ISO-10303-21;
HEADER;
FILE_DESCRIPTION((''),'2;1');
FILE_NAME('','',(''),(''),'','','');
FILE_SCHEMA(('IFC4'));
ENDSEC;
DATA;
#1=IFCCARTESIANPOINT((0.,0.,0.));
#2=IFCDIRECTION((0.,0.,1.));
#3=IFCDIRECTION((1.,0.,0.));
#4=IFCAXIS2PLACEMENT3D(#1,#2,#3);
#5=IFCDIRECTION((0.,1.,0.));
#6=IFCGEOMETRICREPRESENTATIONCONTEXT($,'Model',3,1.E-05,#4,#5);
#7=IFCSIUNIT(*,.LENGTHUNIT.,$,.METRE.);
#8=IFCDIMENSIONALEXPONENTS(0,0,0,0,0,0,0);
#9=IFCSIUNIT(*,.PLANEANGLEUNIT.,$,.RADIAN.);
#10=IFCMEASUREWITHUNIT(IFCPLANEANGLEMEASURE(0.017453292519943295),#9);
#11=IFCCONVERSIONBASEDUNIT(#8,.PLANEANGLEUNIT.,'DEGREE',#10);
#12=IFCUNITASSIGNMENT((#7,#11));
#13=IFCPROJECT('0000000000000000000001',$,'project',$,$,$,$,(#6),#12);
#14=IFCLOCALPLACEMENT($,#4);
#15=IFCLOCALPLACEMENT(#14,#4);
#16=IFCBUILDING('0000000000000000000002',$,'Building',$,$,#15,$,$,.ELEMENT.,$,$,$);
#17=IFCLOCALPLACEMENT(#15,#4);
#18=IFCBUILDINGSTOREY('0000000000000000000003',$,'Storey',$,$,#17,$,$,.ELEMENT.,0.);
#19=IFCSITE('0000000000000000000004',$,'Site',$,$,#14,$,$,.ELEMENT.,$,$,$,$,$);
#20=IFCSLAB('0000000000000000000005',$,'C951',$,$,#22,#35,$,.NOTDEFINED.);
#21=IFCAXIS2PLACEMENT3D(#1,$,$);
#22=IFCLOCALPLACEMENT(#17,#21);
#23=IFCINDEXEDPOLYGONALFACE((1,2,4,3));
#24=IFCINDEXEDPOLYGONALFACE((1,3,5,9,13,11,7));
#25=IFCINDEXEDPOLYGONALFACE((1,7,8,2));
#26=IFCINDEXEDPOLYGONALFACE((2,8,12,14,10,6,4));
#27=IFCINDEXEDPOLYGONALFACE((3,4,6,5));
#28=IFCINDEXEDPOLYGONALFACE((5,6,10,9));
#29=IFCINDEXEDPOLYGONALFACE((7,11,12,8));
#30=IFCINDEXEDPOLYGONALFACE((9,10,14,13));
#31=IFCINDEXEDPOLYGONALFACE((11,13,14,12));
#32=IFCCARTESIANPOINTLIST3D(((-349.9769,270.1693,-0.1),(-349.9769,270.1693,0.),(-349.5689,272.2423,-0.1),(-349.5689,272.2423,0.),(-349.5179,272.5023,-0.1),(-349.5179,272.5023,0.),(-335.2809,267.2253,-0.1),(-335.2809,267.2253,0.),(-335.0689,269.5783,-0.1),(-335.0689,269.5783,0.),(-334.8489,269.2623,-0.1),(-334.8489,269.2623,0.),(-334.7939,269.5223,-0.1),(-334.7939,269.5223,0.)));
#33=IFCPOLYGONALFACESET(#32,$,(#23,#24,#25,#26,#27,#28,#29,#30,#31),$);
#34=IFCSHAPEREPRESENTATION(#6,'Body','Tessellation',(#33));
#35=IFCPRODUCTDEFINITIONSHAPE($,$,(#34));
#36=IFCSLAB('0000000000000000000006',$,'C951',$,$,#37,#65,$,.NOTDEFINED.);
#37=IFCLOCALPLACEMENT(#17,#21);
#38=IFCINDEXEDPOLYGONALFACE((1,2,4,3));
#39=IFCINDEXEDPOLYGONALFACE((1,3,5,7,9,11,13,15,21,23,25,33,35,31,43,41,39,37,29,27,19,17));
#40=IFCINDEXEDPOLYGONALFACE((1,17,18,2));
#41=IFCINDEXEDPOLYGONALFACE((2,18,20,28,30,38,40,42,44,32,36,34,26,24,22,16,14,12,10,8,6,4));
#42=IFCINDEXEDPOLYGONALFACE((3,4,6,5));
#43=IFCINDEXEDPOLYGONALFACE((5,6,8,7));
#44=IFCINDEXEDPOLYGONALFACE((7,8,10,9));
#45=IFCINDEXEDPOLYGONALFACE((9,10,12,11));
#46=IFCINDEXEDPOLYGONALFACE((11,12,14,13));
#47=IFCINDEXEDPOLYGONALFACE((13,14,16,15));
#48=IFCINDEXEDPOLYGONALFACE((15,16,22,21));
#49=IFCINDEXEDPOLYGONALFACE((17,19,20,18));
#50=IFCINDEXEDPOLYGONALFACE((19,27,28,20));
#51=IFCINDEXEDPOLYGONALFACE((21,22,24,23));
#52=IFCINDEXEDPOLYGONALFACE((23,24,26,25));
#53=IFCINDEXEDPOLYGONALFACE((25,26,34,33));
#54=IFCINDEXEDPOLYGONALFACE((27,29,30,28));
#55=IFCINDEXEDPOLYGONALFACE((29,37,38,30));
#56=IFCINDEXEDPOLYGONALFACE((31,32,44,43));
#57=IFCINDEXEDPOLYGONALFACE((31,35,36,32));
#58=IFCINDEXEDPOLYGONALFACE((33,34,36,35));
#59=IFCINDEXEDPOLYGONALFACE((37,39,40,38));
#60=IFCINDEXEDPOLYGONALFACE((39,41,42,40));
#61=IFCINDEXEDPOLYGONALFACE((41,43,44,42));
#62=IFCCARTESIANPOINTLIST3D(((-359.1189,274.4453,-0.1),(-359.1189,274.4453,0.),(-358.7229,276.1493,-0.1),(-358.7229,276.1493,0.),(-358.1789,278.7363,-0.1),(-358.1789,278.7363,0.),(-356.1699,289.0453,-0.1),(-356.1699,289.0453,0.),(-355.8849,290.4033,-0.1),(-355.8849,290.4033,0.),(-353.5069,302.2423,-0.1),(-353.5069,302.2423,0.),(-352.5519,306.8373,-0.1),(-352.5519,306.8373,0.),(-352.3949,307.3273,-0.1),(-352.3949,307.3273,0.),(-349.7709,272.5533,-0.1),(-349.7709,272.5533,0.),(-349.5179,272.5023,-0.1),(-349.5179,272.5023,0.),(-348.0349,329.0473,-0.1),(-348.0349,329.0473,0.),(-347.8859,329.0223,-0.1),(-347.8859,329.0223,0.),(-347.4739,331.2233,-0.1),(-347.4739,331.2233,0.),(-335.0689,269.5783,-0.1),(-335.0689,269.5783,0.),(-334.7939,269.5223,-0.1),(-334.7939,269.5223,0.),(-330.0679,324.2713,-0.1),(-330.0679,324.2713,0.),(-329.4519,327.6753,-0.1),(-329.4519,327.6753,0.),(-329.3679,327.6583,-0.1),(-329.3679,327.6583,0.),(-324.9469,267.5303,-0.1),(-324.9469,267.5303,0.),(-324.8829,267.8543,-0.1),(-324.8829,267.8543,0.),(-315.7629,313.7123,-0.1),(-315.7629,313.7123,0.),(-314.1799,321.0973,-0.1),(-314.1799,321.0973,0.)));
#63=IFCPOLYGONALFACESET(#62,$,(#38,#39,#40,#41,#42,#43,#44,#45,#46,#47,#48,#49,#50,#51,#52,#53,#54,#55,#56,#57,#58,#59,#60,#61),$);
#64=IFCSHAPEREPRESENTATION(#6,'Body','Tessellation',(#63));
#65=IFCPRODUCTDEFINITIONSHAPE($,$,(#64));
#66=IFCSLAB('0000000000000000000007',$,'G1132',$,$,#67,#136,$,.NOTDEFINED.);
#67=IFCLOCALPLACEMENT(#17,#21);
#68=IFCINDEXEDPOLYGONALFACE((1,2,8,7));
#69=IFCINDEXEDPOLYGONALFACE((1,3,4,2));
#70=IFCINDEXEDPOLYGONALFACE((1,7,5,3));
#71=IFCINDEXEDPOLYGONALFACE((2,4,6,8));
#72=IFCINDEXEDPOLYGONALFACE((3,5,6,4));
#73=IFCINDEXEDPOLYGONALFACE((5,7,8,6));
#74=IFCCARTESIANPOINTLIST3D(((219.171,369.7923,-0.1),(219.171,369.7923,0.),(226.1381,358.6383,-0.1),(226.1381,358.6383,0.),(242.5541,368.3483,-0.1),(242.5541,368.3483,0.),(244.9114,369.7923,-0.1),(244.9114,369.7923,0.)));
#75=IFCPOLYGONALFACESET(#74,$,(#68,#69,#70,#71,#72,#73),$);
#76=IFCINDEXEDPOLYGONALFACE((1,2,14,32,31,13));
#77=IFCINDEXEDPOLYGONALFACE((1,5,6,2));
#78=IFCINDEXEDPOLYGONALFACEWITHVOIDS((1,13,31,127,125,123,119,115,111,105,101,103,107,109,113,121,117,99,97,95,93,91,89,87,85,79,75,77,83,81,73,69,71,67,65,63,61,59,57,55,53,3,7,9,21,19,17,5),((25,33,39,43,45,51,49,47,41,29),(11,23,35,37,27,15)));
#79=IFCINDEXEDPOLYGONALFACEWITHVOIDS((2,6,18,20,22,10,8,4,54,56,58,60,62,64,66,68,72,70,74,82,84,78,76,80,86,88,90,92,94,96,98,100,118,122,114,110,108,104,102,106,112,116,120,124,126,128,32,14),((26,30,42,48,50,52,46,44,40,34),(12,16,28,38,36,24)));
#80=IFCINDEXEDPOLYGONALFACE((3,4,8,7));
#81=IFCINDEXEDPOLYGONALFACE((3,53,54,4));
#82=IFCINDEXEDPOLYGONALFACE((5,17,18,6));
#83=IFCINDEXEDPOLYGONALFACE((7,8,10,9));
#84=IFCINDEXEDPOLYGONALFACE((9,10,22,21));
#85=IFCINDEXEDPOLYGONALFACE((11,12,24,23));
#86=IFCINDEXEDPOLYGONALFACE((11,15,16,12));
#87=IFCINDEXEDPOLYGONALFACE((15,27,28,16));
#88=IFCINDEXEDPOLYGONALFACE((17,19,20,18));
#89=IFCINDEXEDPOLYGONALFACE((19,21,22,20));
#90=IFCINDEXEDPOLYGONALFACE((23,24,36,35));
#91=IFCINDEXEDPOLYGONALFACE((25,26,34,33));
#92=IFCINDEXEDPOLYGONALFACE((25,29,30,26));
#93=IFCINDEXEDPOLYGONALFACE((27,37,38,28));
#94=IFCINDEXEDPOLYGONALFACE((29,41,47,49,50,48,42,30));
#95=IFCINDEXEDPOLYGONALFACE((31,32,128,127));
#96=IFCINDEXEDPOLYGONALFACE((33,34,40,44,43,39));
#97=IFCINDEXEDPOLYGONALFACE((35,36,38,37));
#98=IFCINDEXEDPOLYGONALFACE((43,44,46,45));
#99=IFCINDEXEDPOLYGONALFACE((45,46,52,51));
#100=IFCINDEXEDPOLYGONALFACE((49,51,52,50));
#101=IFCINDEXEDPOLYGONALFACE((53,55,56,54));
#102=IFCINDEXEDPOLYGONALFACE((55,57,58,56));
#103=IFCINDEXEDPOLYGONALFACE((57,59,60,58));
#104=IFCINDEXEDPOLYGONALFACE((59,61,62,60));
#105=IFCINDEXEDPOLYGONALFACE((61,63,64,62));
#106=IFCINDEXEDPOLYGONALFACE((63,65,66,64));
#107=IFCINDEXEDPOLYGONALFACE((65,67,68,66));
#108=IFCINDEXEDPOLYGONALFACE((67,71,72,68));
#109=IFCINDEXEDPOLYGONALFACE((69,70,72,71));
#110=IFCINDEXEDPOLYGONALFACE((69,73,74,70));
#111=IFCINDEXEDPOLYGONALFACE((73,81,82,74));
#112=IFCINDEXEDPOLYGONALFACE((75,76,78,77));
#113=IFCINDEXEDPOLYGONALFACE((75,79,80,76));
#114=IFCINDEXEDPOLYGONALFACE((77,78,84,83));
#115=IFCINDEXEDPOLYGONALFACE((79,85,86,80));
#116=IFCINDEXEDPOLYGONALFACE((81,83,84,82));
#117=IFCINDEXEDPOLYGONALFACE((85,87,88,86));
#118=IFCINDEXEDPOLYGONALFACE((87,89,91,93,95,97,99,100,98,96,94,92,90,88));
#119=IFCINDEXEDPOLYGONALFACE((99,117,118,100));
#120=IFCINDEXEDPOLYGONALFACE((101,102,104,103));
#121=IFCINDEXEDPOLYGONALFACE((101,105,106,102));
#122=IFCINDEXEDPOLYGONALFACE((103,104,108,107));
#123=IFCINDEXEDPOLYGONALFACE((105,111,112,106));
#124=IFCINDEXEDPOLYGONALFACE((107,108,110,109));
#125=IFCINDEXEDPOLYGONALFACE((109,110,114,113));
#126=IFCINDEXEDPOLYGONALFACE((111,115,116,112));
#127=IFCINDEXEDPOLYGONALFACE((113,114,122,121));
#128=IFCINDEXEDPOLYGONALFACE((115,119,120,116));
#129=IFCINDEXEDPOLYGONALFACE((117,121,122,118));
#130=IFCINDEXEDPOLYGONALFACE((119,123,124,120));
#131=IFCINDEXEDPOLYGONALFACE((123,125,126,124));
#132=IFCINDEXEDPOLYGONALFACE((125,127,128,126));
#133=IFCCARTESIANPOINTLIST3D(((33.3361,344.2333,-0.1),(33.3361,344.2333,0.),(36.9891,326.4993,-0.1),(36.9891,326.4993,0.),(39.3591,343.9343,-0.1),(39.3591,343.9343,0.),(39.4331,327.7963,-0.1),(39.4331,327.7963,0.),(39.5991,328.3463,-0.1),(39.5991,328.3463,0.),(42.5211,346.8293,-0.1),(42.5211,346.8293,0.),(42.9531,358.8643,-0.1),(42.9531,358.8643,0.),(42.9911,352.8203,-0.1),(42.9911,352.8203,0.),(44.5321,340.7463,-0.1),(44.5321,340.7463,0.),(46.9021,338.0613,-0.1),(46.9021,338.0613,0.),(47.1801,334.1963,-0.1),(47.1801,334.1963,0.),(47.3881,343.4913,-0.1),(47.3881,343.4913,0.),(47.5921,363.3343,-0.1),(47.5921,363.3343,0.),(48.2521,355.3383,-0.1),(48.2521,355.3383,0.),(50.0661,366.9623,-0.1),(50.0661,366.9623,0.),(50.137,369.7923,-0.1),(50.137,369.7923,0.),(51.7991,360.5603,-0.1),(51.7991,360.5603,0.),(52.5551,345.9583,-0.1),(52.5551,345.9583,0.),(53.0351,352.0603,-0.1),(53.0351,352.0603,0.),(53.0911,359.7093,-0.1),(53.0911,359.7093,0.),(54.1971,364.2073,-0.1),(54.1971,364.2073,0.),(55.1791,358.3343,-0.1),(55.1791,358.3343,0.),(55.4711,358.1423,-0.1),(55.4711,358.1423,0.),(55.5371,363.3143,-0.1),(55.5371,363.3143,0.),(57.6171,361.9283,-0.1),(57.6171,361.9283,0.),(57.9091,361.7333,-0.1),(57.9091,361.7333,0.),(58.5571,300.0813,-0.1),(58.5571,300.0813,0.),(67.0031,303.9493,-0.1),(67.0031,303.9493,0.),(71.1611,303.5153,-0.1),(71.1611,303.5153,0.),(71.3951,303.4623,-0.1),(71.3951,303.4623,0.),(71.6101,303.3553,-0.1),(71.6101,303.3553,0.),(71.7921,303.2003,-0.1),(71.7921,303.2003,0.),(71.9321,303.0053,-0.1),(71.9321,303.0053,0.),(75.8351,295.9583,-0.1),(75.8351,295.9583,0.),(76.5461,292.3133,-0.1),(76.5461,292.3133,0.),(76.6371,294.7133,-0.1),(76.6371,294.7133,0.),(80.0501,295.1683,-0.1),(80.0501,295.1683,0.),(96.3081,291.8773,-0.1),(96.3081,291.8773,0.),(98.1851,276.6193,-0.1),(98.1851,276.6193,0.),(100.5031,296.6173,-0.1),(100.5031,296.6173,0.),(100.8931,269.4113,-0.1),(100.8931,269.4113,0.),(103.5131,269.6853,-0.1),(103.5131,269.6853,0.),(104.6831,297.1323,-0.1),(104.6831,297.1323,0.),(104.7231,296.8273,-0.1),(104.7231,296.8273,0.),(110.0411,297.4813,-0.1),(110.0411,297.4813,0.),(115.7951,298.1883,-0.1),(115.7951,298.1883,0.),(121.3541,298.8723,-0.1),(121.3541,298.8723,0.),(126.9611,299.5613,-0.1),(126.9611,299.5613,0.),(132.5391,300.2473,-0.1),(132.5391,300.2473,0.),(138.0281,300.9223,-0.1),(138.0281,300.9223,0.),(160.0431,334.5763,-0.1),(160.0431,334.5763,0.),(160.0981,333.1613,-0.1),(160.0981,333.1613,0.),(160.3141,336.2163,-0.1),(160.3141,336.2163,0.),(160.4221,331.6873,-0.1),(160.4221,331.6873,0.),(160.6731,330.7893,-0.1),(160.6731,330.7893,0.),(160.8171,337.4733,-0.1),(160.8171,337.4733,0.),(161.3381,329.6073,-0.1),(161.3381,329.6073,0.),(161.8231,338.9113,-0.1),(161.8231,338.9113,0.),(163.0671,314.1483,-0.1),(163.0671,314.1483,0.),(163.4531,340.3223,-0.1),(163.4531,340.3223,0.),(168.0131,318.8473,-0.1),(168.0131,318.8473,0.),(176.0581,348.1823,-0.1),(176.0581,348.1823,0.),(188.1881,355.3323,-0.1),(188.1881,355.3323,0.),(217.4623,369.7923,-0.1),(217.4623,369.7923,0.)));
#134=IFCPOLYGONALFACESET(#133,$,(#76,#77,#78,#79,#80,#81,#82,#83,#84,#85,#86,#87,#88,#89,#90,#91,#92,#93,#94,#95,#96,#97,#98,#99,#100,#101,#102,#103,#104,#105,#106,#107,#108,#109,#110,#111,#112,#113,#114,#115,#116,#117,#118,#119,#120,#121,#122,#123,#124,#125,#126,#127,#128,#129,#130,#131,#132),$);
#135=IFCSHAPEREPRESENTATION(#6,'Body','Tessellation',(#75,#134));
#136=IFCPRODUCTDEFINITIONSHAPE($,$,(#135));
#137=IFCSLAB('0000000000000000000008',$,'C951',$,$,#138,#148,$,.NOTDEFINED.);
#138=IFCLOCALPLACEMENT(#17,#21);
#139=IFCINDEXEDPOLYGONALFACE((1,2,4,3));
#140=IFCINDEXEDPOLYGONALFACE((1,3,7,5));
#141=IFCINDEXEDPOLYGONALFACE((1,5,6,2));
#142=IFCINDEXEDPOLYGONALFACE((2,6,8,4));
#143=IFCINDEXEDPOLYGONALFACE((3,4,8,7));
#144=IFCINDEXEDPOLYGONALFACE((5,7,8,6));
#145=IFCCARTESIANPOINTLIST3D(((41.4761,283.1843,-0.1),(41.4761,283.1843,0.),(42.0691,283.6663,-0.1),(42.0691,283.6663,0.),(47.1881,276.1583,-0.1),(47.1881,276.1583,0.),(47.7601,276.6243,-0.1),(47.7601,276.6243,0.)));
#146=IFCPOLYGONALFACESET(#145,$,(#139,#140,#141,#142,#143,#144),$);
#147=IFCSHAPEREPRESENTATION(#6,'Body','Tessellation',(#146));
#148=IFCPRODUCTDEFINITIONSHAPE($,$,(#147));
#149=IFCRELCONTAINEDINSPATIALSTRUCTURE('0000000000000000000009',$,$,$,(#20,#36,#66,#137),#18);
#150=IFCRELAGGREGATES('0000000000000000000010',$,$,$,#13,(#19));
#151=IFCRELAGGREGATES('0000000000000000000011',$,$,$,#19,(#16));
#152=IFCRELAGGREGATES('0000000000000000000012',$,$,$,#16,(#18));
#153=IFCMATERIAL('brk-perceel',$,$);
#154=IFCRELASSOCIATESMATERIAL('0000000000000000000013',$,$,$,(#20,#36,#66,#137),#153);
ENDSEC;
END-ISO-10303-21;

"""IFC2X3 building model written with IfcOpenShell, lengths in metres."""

from ifc_helpers import new_model, entity, si_unit, converted_unit, direction, frame, origin_with_axes, place, context, project, spatial, polyline, outline, extrude, material, element, save


model = new_model("IFC2X3")

# Units and contexts
model_context = context("Model", 3, precision=1e-05, world=origin_with_axes(), true_north=direction((0.0, 1.0, 0.0)))
ifc_project = project(units=[si_unit("LENGTHUNIT", "METRE"), converted_unit("PLANEANGLEUNIT", "DEGREE", entity("IfcPlaneAngleMeasure", 0.017453292519943295), si_unit("PLANEANGLEUNIT", "RADIAN"), dimensions=[0, 0, 0, 0, 0, 0, 0])], contexts=[model_context])

# Site, building, storey
site_placement = place(None, origin_with_axes())
site = spatial("IfcSite", under=ifc_project, at=site_placement, Name="Site", CompositionType="ELEMENT")
building_placement = place(site_placement, origin_with_axes())
building = spatial("IfcBuilding", under=site, at=building_placement, Name="Building", CompositionType="ELEMENT")
storey_placement = place(building_placement, origin_with_axes())
storey = spatial("IfcBuildingStorey", under=building, at=storey_placement, Name="Storey", CompositionType="ELEMENT", Elevation=0.0)

# Slabs
ifc_material = material(Name="brk-perceel")
slab_1_placement = place(storey_placement, frame((0.0, 0.0, -0.1), z_axis=(0.0, 0.0, 1.0), x_axis=(1.0, 0.0, 0.0)))
element("IfcSlab", 1, at=slab_1_placement, inside=storey, material=ifc_material, Name="C951", PredefinedType="NOTDEFINED", context=model_context, shape_type="SweptSolid", body=[
    extrude(outline(polyline([(-335.0689, 269.5783), (-334.7939, 269.5223), (-334.8489, 269.2623), (-335.2809, 267.2253), (-349.9769, 270.1693), (-349.5689, 272.2423), (-349.5179, 272.5023), (-335.0689, 269.5783)])), origin_with_axes(), (0.0, 0.0, 1.0), 0.1),
])
slab_2_placement = place(storey_placement, frame((0.0, 0.0, -0.1), z_axis=(0.0, 0.0, 1.0), x_axis=(1.0, 0.0, 0.0)))
element("IfcSlab", 2, at=slab_2_placement, inside=storey, material=ifc_material, Name="C951", PredefinedType="NOTDEFINED", context=model_context, shape_type="SweptSolid", body=[
    extrude(outline(polyline([(-358.1789, 278.7363), (-356.1699, 289.0453), (-355.8849, 290.4033), (-353.5069, 302.2423), (-352.5519, 306.8373), (-352.3949, 307.3273), (-348.0349, 329.0473), (-347.8859, 329.0223), (-347.4739, 331.2233), (-329.4519, 327.6753), (-329.3679, 327.6583), (-330.0679, 324.2713), (-314.1799, 321.0973), (-315.7629, 313.7123), (-324.8829, 267.8543), (-324.9469, 267.5303), (-334.7939, 269.5223), (-335.0689, 269.5783), (-349.5179, 272.5023), (-349.7709, 272.5533), (-359.1189, 274.4453), (-358.7229, 276.1493), (-358.1789, 278.7363)])), origin_with_axes(), (0.0, 0.0, 1.0), 0.1),
])
slab_3_placement = place(storey_placement, frame((0.0, 0.0, -0.1), z_axis=(0.0, 0.0, 1.0), x_axis=(1.0, 0.0, 0.0)))
element("IfcSlab", 3, at=slab_3_placement, inside=storey, material=ifc_material, Name="G1132", PredefinedType="NOTDEFINED", context=model_context, shape_type="SweptSolid", body=[
    extrude(outline(polyline([(242.5541, 368.3483), (226.1381, 358.6383), (219.171, 369.7923), (244.9114, 369.7923), (242.5541, 368.3483)])), origin_with_axes(), (0.0, 0.0, 1.0), 0.1),
    extrude(outline(polyline([(188.1881, 355.3323), (176.0581, 348.1823), (163.4531, 340.3223), (161.8231, 338.9113), (160.8171, 337.4733), (160.3141, 336.2163), (160.0431, 334.5763), (160.0981, 333.1613), (160.4221, 331.6873), (160.6731, 330.7893), (161.3381, 329.6073), (168.0131, 318.8473), (163.0671, 314.1483), (138.0281, 300.9223), (132.5391, 300.2473), (126.9611, 299.5613), (121.3541, 298.8723), (115.7951, 298.1883), (110.0411, 297.4813), (104.7231, 296.8273), (104.6831, 297.1323), (100.5031, 296.6173), (96.3081, 291.8773), (98.1851, 276.6193), (103.5131, 269.6853), (100.8931, 269.4113), (80.0501, 295.1683), (76.5461, 292.3133), (76.6371, 294.7133), (75.8351, 295.9583), (71.9321, 303.0053), (71.7921, 303.2003), (71.6101, 303.3553), (71.3951, 303.4623), (71.1611, 303.5153), (67.0031, 303.9493), (58.5571, 300.0813), (36.9891, 326.4993), (39.4331, 327.7963), (39.5991, 328.3463), (47.1801, 334.1963), (46.9021, 338.0613), (44.5321, 340.7463), (39.3591, 343.9343), (33.3361, 344.2333), (42.9531, 358.8643), (50.137, 369.7923), (217.4623, 369.7923), (188.1881, 355.3323)]), holes=[polyline([(51.7991, 360.5603), (53.0911, 359.7093), (55.1791, 358.3343), (55.4711, 358.1423), (57.9091, 361.7333), (57.6171, 361.9283), (55.5371, 363.3143), (54.1971, 364.2073), (50.0661, 366.9623), (47.5921, 363.3343), (51.7991, 360.5603)]), polyline([(47.3881, 343.4913), (52.5551, 345.9583), (53.0351, 352.0603), (48.2521, 355.3383), (42.9911, 352.8203), (42.5211, 346.8293), (47.3881, 343.4913)])]), origin_with_axes(), (0.0, 0.0, 1.0), 0.1),
])
slab_4_placement = place(storey_placement, frame((0.0, 0.0, -0.1), z_axis=(0.0, 0.0, 1.0), x_axis=(1.0, 0.0, 0.0)))
element("IfcSlab", 4, at=slab_4_placement, inside=storey, material=ifc_material, Name="C951", PredefinedType="NOTDEFINED", context=model_context, shape_type="SweptSolid", body=[
    extrude(outline(polyline([(47.1881, 276.1583), (41.4761, 283.1843), (42.0691, 283.6663), (47.7601, 276.6243), (47.1881, 276.1583)])), origin_with_axes(), (0.0, 0.0, 1.0), 0.1),
])

save(model, "model.ifc")
